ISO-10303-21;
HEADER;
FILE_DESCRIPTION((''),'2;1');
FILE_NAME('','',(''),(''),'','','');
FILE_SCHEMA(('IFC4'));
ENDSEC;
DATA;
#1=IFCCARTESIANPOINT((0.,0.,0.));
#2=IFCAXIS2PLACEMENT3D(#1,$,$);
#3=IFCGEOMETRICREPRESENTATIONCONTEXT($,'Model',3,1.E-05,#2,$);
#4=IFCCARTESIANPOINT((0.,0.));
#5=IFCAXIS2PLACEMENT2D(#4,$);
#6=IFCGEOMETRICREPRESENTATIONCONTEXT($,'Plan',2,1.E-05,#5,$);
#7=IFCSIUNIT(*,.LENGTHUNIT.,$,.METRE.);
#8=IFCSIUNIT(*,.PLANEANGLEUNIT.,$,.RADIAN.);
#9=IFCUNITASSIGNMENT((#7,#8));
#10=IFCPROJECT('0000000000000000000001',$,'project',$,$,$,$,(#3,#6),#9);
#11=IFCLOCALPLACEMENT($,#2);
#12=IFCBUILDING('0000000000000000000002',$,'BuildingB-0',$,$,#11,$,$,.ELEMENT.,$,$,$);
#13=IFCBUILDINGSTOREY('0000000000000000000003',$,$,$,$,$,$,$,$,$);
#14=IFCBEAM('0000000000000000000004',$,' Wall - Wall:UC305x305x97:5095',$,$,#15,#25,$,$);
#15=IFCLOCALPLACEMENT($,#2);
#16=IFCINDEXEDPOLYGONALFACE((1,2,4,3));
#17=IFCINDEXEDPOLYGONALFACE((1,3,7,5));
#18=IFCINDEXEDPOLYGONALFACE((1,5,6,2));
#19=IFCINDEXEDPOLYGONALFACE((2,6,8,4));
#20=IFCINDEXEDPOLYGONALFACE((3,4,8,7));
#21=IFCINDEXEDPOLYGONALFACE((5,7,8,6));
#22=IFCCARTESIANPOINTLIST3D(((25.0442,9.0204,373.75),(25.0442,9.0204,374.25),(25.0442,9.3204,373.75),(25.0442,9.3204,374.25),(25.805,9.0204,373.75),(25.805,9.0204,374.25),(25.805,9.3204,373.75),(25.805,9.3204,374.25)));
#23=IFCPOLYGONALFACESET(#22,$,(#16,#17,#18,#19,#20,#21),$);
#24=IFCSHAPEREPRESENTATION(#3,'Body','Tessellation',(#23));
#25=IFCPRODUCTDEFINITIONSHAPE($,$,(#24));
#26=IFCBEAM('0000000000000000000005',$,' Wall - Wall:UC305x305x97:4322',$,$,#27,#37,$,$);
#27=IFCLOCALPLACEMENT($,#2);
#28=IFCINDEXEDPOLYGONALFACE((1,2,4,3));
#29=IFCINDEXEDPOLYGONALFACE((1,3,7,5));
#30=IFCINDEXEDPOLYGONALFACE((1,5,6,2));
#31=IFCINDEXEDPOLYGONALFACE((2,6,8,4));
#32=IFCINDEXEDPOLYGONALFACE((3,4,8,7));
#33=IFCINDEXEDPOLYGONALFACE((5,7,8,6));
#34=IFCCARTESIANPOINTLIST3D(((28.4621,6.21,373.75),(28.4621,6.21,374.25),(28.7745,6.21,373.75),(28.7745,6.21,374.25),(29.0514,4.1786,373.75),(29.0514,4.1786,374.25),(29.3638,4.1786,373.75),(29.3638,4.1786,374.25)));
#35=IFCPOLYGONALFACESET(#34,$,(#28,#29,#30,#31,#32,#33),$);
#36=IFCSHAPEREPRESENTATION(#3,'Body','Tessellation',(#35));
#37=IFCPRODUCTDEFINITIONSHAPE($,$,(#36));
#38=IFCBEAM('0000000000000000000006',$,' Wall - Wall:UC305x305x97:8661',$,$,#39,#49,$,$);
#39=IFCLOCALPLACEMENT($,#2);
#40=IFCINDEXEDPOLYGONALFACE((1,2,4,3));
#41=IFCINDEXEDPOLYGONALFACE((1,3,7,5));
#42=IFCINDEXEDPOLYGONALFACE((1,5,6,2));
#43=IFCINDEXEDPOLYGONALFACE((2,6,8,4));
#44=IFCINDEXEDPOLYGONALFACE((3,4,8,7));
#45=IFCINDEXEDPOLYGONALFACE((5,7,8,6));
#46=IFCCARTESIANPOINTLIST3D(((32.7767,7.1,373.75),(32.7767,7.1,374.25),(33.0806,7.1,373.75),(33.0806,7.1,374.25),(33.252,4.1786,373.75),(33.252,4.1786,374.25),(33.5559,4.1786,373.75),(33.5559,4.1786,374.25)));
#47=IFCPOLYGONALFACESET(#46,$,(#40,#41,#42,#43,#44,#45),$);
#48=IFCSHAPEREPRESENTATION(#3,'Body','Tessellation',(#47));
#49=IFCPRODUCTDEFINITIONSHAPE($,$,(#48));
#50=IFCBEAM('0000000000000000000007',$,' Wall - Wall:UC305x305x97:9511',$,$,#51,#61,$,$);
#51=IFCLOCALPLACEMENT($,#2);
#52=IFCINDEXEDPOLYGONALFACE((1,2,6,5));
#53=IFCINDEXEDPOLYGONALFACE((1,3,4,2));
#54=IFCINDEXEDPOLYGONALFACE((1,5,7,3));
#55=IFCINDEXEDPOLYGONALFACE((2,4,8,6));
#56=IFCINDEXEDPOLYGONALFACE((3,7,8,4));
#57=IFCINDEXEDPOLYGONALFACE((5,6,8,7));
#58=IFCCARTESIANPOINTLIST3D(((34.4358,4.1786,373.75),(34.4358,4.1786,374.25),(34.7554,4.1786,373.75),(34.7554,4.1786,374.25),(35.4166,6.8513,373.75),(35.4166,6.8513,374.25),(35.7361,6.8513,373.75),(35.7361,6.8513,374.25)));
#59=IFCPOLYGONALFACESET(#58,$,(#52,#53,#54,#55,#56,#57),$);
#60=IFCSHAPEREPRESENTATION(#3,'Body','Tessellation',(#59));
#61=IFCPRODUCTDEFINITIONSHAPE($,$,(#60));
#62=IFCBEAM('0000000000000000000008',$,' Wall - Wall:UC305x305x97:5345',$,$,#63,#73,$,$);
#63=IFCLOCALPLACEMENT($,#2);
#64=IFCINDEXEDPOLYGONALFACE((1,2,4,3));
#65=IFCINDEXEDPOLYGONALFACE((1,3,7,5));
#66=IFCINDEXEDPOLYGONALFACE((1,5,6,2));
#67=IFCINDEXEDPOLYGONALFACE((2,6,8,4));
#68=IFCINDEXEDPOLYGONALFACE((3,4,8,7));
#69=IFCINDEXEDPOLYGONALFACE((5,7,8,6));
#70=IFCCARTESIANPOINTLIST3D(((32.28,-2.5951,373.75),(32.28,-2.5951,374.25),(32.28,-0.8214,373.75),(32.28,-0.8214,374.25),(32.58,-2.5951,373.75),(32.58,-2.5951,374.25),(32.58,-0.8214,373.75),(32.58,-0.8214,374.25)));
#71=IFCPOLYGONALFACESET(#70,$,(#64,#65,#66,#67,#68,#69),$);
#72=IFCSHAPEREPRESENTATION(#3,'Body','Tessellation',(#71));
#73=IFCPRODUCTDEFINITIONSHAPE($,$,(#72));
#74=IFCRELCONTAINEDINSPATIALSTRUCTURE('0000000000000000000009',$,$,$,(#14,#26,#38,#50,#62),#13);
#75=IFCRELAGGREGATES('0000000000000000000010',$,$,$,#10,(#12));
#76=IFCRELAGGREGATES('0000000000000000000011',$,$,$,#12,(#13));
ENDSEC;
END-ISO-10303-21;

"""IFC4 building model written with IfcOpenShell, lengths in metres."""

from ifc_helpers import new_model, si_unit, origin, origin_2d, place, context, project, spatial, polyline, outline, extrude, element, save


model = new_model("IFC4")

# Units and contexts
model_context = context("Model", 3, precision=1e-05, world=origin())
plan_context = context("Plan", 2, precision=1e-05, world=origin_2d())
ifc_project = project(units=[si_unit("LENGTHUNIT", "METRE"), si_unit("PLANEANGLEUNIT", "RADIAN")], contexts=[model_context, plan_context])

# Building, storey
building_placement = place(None, origin())
building = spatial("IfcBuilding", under=ifc_project, at=building_placement, Name="BuildingB-0", CompositionType="ELEMENT")
storey = spatial("IfcBuildingStorey", under=building)

# Beams
element("IfcBeam", 1, inside=storey, Name=" Wall - Wall:UC305x305x97:5095", context=model_context, shape_type="SweptSolid", body=[
    extrude(outline(polyline([(25.0442, 9.0204, 373.75), (25.805, 9.0204, 373.75), (25.805, 9.3204, 373.75), (25.0442, 9.3204, 373.75), (25.0442, 9.0204, 373.75)])), None, (0.0, 0.0, 1.0), 0.5),
])
element("IfcBeam", 2, inside=storey, Name=" Wall - Wall:UC305x305x97:4322", context=model_context, shape_type="SweptSolid", body=[
    extrude(outline(polyline([(29.0514, 4.1786, 373.75), (29.3638, 4.1786, 373.75), (28.7745, 6.21, 373.75), (28.4621, 6.21, 373.75), (29.0514, 4.1786, 373.75)])), None, (0.0, 0.0, 1.0), 0.5),
])
element("IfcBeam", 3, inside=storey, Name=" Wall - Wall:UC305x305x97:8661", context=model_context, shape_type="SweptSolid", body=[
    extrude(outline(polyline([(33.252, 4.1786, 373.75), (33.5559, 4.1786, 373.75), (33.0806, 7.1, 373.75), (32.7767, 7.1, 373.75), (33.252, 4.1786, 373.75)])), None, (0.0, 0.0, 1.0), 0.5),
])
element("IfcBeam", 4, inside=storey, Name=" Wall - Wall:UC305x305x97:9511", context=model_context, shape_type="SweptSolid", body=[
    extrude(outline(polyline([(34.4358, 4.1786, 373.75), (34.7554, 4.1786, 373.75), (35.7361, 6.8513, 373.75), (35.4166, 6.8513, 373.75), (34.4358, 4.1786, 373.75)])), None, (0.0, 0.0, 1.0), 0.5),
])
element("IfcBeam", 5, inside=storey, Name=" Wall - Wall:UC305x305x97:5345", context=model_context, shape_type="SweptSolid", body=[
    extrude(outline(polyline([(32.28, -2.5951, 373.75), (32.58, -2.5951, 373.75), (32.58, -0.8214, 373.75), (32.28, -0.8214, 373.75), (32.28, -2.5951, 373.75)])), None, (0.0, 0.0, 1.0), 0.5),
])

save(model, "model.ifc")
